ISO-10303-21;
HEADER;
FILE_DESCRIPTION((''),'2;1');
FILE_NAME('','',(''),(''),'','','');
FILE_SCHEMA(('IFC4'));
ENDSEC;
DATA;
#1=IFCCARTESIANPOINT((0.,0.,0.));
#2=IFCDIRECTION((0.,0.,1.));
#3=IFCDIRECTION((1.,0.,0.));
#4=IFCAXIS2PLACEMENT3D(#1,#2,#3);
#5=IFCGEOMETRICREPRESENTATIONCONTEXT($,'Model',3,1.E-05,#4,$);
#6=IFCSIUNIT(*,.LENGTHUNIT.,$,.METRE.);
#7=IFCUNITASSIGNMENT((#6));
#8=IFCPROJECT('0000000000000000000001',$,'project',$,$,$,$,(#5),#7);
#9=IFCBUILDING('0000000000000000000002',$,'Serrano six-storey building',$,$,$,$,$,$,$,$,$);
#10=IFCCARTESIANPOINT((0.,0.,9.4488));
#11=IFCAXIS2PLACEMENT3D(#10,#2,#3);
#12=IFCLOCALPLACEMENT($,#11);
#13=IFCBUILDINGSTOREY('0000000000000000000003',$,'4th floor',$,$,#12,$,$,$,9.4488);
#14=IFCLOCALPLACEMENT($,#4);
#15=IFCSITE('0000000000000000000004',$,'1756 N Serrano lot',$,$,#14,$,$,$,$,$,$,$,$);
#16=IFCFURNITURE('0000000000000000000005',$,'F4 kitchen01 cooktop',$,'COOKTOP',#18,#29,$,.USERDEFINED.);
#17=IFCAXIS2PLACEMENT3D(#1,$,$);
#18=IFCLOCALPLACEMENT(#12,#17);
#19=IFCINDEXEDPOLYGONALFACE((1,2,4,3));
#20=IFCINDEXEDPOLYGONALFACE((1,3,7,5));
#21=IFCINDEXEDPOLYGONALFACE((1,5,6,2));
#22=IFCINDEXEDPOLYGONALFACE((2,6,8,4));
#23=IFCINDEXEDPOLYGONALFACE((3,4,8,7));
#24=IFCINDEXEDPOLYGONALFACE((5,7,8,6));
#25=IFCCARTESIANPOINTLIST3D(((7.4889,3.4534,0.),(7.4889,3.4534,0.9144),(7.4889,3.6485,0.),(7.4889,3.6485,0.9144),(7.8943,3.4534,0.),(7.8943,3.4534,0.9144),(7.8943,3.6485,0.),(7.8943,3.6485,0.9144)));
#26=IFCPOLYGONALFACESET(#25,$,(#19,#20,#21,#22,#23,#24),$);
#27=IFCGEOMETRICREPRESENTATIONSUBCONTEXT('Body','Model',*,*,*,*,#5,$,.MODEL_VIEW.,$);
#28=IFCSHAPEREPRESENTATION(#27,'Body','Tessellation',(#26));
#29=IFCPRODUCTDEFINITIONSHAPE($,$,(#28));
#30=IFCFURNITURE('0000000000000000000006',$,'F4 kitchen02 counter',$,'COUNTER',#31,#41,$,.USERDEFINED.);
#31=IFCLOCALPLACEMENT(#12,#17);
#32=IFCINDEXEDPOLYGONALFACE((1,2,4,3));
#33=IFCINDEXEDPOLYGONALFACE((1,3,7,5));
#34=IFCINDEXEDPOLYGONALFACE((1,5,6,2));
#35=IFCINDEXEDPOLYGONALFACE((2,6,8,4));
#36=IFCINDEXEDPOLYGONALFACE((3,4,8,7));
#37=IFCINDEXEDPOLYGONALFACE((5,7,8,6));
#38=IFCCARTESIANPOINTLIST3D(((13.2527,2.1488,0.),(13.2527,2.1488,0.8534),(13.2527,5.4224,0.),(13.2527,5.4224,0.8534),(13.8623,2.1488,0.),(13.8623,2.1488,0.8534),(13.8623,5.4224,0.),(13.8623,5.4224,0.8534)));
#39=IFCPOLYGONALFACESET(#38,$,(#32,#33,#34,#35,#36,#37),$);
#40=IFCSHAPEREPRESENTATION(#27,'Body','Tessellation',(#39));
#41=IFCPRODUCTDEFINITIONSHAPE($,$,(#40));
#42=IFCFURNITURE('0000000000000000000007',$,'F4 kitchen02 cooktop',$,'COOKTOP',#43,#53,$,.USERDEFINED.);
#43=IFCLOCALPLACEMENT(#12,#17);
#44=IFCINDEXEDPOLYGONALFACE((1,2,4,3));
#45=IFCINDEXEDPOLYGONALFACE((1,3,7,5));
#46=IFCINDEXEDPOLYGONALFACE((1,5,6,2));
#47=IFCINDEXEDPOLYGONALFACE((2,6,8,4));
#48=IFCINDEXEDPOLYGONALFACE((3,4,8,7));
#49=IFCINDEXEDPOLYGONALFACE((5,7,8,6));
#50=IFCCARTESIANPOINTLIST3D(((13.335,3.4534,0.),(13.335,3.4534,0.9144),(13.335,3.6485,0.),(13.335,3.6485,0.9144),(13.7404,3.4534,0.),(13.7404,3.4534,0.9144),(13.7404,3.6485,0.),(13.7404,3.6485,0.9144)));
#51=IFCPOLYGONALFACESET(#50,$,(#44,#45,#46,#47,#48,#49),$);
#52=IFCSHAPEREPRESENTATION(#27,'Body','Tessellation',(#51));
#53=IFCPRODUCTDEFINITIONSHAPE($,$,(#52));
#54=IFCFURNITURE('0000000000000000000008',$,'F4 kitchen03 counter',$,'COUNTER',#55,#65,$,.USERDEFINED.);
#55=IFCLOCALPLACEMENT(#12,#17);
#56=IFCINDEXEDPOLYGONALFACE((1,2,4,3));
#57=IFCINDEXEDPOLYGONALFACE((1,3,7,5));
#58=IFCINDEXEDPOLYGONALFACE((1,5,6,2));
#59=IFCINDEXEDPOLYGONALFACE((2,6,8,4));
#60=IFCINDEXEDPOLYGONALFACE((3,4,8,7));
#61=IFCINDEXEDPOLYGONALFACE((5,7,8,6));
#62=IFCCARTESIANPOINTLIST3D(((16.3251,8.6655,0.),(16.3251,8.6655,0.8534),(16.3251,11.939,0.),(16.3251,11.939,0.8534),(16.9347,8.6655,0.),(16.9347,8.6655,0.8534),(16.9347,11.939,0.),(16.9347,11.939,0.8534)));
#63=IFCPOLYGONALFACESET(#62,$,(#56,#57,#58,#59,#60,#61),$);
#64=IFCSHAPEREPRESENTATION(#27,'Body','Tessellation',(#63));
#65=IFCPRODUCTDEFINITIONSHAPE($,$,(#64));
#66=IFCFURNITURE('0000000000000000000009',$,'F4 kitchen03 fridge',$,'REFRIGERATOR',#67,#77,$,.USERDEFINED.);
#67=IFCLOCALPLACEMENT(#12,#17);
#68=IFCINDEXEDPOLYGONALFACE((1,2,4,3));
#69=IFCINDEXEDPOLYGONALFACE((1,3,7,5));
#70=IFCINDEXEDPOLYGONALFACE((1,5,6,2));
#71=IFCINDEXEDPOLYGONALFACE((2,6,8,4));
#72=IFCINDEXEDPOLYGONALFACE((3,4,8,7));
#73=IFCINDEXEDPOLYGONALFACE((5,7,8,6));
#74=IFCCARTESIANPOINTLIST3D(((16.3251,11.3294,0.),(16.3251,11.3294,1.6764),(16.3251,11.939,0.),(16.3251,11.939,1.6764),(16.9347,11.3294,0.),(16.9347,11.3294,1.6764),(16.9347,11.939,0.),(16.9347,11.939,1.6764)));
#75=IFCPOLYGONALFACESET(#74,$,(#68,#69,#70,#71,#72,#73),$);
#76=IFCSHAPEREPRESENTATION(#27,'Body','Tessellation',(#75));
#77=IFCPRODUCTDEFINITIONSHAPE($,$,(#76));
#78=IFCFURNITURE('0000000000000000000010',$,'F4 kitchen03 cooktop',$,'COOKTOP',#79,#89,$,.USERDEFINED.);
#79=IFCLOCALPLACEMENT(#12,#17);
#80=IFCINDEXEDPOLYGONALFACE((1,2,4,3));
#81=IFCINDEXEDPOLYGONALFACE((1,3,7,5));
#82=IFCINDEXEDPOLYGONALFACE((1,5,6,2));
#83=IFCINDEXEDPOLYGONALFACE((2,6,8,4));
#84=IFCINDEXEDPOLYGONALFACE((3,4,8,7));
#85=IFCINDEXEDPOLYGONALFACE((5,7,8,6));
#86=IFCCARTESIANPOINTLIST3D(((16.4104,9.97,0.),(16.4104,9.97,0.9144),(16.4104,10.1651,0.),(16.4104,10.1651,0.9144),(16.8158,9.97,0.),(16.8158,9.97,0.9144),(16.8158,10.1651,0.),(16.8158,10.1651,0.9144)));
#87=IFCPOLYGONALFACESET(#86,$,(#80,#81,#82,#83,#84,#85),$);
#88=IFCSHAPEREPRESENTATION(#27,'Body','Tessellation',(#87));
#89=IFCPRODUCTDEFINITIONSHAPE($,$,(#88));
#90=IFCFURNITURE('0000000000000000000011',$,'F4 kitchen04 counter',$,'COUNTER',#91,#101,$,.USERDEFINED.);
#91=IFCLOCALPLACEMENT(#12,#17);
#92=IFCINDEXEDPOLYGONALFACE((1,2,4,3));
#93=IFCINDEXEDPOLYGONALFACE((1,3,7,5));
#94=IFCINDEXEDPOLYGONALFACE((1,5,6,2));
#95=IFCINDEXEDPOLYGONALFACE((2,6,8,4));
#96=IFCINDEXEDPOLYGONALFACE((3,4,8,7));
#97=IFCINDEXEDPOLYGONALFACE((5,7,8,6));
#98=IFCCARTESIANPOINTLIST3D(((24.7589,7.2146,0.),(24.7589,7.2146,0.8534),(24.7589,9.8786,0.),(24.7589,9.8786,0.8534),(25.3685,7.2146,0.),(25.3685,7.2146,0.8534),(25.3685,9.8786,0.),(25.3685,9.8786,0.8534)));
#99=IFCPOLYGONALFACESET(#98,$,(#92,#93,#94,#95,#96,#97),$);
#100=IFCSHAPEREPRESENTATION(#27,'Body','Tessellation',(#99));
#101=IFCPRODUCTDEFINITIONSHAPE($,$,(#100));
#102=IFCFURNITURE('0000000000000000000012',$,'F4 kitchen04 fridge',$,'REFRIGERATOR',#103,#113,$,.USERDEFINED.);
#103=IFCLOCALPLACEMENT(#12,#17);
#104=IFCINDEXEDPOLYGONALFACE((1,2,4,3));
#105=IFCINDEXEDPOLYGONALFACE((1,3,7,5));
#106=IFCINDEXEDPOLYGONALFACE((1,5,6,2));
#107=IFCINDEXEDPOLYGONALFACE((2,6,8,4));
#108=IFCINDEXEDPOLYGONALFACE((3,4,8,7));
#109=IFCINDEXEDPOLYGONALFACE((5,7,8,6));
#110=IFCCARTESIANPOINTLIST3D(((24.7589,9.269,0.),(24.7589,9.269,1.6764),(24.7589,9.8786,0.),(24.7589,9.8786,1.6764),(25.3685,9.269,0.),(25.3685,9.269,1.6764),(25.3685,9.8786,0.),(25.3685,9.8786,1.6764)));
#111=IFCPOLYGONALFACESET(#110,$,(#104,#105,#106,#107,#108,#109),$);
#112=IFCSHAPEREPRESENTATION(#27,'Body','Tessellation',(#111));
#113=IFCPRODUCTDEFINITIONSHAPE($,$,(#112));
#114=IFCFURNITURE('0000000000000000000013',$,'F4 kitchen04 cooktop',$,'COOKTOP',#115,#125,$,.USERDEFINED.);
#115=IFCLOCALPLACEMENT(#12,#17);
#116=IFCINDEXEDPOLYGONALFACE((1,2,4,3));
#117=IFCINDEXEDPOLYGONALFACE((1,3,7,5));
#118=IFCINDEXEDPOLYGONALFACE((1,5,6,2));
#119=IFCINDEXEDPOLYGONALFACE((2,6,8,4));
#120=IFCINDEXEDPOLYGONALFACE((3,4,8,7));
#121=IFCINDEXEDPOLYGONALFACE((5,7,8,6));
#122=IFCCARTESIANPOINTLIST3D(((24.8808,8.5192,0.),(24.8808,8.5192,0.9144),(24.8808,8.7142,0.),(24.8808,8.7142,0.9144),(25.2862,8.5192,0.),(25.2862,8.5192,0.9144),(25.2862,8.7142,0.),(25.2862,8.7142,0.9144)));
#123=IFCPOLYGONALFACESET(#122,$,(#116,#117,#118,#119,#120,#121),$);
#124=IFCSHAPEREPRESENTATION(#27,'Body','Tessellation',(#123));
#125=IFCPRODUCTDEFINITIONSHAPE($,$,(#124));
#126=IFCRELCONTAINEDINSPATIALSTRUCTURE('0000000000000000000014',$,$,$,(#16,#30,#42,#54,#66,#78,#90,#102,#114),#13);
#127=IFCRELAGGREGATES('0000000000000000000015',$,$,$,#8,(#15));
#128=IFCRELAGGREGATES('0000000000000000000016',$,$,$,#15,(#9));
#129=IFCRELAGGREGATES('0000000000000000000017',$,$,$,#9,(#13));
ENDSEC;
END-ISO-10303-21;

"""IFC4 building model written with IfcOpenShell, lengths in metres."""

from ifc_helpers import new_model, si_unit, frame, origin_with_axes, place, context, subcontext, project, spatial, polyline, outline, extrude, element, save


model = new_model("IFC4")

# Units and contexts
model_context = context("Model", 3, precision=1e-05, world=origin_with_axes())
body_context = subcontext(model_context, "Body", "Model", "MODEL_VIEW")
ifc_project = project(units=[si_unit("LENGTHUNIT", "METRE")], contexts=[model_context])

# Site, building, storey
site_placement = place(None, origin_with_axes())
site = spatial("IfcSite", under=ifc_project, at=site_placement, Name="1756 N Serrano lot")
building = spatial("IfcBuilding", under=site, Name="Serrano six-storey building")
storey_placement = place(None, frame((0.0, 0.0, 9.4488), z_axis=(0.0, 0.0, 1.0), x_axis=(1.0, 0.0, 0.0)))
storey = spatial("IfcBuildingStorey", under=building, at=storey_placement, Name="4th floor", Elevation=9.4488)

# Furniture
furniture_1_placement = place(storey_placement, frame((0.0, 0.0, -9.4488), z_axis=(0.0, 0.0, 1.0), x_axis=(1.0, 0.0, 0.0)))
element("IfcFurniture", 1, at=furniture_1_placement, inside=storey, Name="F4 kitchen01 cooktop", ObjectType="COOKTOP", PredefinedType="USERDEFINED", context=body_context, shape_type="SweptSolid", body=[
    extrude(outline(polyline([(7.8943, 3.4534), (7.8943, 3.6485), (7.4889, 3.6485), (7.4889, 3.4534), (7.8943, 3.4534)])), frame((0.0, 0.0, 9.4488)), (0.0, 0.0, 1.0), 0.9144),
])
furniture_2_placement = place(storey_placement, frame((0.0, 0.0, -9.4488), z_axis=(0.0, 0.0, 1.0), x_axis=(1.0, 0.0, 0.0)))
element("IfcFurniture", 2, at=furniture_2_placement, inside=storey, Name="F4 kitchen02 counter", ObjectType="COUNTER", PredefinedType="USERDEFINED", context=body_context, shape_type="SweptSolid", body=[
    extrude(outline(polyline([(13.8623, 2.1488), (13.8623, 5.4224), (13.2527, 5.4224), (13.2527, 2.1488), (13.8623, 2.1488)])), frame((0.0, 0.0, 9.4488)), (0.0, 0.0, 1.0), 0.8534),
])
furniture_3_placement = place(storey_placement, frame((0.0, 0.0, -9.4488), z_axis=(0.0, 0.0, 1.0), x_axis=(1.0, 0.0, 0.0)))
element("IfcFurniture", 3, at=furniture_3_placement, inside=storey, Name="F4 kitchen02 cooktop", ObjectType="COOKTOP", PredefinedType="USERDEFINED", context=body_context, shape_type="SweptSolid", body=[
    extrude(outline(polyline([(13.7404, 3.4534), (13.7404, 3.6485), (13.335, 3.6485), (13.335, 3.4534), (13.7404, 3.4534)])), frame((0.0, 0.0, 9.4488)), (0.0, 0.0, 1.0), 0.9144),
])
furniture_4_placement = place(storey_placement, frame((0.0, 0.0, -9.4488), z_axis=(0.0, 0.0, 1.0), x_axis=(1.0, 0.0, 0.0)))
element("IfcFurniture", 4, at=furniture_4_placement, inside=storey, Name="F4 kitchen03 counter", ObjectType="COUNTER", PredefinedType="USERDEFINED", context=body_context, shape_type="SweptSolid", body=[
    extrude(outline(polyline([(16.9347, 8.6655), (16.9347, 11.939), (16.3251, 11.939), (16.3251, 8.6655), (16.9347, 8.6655)])), frame((0.0, 0.0, 9.4488)), (0.0, 0.0, 1.0), 0.8534),
])
furniture_5_placement = place(storey_placement, frame((0.0, 0.0, -9.4488), z_axis=(0.0, 0.0, 1.0), x_axis=(1.0, 0.0, 0.0)))
element("IfcFurniture", 5, at=furniture_5_placement, inside=storey, Name="F4 kitchen03 fridge", ObjectType="REFRIGERATOR", PredefinedType="USERDEFINED", context=body_context, shape_type="SweptSolid", body=[
    extrude(outline(polyline([(16.9347, 11.3294), (16.9347, 11.939), (16.3251, 11.939), (16.3251, 11.3294), (16.9347, 11.3294)])), frame((0.0, 0.0, 9.4488)), (0.0, 0.0, 1.0), 1.6764),
])
furniture_6_placement = place(storey_placement, frame((0.0, 0.0, -9.4488), z_axis=(0.0, 0.0, 1.0), x_axis=(1.0, 0.0, 0.0)))
element("IfcFurniture", 6, at=furniture_6_placement, inside=storey, Name="F4 kitchen03 cooktop", ObjectType="COOKTOP", PredefinedType="USERDEFINED", context=body_context, shape_type="SweptSolid", body=[
    extrude(outline(polyline([(16.8158, 9.97), (16.8158, 10.1651), (16.4104, 10.1651), (16.4104, 9.97), (16.8158, 9.97)])), frame((0.0, 0.0, 9.4488)), (0.0, 0.0, 1.0), 0.9144),
])
furniture_7_placement = place(storey_placement, frame((0.0, 0.0, -9.4488), z_axis=(0.0, 0.0, 1.0), x_axis=(1.0, 0.0, 0.0)))
element("IfcFurniture", 7, at=furniture_7_placement, inside=storey, Name="F4 kitchen04 counter", ObjectType="COUNTER", PredefinedType="USERDEFINED", context=body_context, shape_type="SweptSolid", body=[
    extrude(outline(polyline([(25.3685, 7.2146), (25.3685, 9.8786), (24.7589, 9.8786), (24.7589, 7.2146), (25.3685, 7.2146)])), frame((0.0, 0.0, 9.4488)), (0.0, 0.0, 1.0), 0.8534),
])
furniture_8_placement = place(storey_placement, frame((0.0, 0.0, -9.4488), z_axis=(0.0, 0.0, 1.0), x_axis=(1.0, 0.0, 0.0)))
element("IfcFurniture", 8, at=furniture_8_placement, inside=storey, Name="F4 kitchen04 fridge", ObjectType="REFRIGERATOR", PredefinedType="USERDEFINED", context=body_context, shape_type="SweptSolid", body=[
    extrude(outline(polyline([(25.3685, 9.269), (25.3685, 9.8786), (24.7589, 9.8786), (24.7589, 9.269), (25.3685, 9.269)])), frame((0.0, 0.0, 9.4488)), (0.0, 0.0, 1.0), 1.6764),
])
furniture_9_placement = place(storey_placement, frame((0.0, 0.0, -9.4488), z_axis=(0.0, 0.0, 1.0), x_axis=(1.0, 0.0, 0.0)))
element("IfcFurniture", 9, at=furniture_9_placement, inside=storey, Name="F4 kitchen04 cooktop", ObjectType="COOKTOP", PredefinedType="USERDEFINED", context=body_context, shape_type="SweptSolid", body=[
    extrude(outline(polyline([(25.2862, 8.5192), (25.2862, 8.7142), (24.8808, 8.7142), (24.8808, 8.5192), (25.2862, 8.5192)])), frame((0.0, 0.0, 9.4488)), (0.0, 0.0, 1.0), 0.9144),
])

save(model, "model.ifc")
